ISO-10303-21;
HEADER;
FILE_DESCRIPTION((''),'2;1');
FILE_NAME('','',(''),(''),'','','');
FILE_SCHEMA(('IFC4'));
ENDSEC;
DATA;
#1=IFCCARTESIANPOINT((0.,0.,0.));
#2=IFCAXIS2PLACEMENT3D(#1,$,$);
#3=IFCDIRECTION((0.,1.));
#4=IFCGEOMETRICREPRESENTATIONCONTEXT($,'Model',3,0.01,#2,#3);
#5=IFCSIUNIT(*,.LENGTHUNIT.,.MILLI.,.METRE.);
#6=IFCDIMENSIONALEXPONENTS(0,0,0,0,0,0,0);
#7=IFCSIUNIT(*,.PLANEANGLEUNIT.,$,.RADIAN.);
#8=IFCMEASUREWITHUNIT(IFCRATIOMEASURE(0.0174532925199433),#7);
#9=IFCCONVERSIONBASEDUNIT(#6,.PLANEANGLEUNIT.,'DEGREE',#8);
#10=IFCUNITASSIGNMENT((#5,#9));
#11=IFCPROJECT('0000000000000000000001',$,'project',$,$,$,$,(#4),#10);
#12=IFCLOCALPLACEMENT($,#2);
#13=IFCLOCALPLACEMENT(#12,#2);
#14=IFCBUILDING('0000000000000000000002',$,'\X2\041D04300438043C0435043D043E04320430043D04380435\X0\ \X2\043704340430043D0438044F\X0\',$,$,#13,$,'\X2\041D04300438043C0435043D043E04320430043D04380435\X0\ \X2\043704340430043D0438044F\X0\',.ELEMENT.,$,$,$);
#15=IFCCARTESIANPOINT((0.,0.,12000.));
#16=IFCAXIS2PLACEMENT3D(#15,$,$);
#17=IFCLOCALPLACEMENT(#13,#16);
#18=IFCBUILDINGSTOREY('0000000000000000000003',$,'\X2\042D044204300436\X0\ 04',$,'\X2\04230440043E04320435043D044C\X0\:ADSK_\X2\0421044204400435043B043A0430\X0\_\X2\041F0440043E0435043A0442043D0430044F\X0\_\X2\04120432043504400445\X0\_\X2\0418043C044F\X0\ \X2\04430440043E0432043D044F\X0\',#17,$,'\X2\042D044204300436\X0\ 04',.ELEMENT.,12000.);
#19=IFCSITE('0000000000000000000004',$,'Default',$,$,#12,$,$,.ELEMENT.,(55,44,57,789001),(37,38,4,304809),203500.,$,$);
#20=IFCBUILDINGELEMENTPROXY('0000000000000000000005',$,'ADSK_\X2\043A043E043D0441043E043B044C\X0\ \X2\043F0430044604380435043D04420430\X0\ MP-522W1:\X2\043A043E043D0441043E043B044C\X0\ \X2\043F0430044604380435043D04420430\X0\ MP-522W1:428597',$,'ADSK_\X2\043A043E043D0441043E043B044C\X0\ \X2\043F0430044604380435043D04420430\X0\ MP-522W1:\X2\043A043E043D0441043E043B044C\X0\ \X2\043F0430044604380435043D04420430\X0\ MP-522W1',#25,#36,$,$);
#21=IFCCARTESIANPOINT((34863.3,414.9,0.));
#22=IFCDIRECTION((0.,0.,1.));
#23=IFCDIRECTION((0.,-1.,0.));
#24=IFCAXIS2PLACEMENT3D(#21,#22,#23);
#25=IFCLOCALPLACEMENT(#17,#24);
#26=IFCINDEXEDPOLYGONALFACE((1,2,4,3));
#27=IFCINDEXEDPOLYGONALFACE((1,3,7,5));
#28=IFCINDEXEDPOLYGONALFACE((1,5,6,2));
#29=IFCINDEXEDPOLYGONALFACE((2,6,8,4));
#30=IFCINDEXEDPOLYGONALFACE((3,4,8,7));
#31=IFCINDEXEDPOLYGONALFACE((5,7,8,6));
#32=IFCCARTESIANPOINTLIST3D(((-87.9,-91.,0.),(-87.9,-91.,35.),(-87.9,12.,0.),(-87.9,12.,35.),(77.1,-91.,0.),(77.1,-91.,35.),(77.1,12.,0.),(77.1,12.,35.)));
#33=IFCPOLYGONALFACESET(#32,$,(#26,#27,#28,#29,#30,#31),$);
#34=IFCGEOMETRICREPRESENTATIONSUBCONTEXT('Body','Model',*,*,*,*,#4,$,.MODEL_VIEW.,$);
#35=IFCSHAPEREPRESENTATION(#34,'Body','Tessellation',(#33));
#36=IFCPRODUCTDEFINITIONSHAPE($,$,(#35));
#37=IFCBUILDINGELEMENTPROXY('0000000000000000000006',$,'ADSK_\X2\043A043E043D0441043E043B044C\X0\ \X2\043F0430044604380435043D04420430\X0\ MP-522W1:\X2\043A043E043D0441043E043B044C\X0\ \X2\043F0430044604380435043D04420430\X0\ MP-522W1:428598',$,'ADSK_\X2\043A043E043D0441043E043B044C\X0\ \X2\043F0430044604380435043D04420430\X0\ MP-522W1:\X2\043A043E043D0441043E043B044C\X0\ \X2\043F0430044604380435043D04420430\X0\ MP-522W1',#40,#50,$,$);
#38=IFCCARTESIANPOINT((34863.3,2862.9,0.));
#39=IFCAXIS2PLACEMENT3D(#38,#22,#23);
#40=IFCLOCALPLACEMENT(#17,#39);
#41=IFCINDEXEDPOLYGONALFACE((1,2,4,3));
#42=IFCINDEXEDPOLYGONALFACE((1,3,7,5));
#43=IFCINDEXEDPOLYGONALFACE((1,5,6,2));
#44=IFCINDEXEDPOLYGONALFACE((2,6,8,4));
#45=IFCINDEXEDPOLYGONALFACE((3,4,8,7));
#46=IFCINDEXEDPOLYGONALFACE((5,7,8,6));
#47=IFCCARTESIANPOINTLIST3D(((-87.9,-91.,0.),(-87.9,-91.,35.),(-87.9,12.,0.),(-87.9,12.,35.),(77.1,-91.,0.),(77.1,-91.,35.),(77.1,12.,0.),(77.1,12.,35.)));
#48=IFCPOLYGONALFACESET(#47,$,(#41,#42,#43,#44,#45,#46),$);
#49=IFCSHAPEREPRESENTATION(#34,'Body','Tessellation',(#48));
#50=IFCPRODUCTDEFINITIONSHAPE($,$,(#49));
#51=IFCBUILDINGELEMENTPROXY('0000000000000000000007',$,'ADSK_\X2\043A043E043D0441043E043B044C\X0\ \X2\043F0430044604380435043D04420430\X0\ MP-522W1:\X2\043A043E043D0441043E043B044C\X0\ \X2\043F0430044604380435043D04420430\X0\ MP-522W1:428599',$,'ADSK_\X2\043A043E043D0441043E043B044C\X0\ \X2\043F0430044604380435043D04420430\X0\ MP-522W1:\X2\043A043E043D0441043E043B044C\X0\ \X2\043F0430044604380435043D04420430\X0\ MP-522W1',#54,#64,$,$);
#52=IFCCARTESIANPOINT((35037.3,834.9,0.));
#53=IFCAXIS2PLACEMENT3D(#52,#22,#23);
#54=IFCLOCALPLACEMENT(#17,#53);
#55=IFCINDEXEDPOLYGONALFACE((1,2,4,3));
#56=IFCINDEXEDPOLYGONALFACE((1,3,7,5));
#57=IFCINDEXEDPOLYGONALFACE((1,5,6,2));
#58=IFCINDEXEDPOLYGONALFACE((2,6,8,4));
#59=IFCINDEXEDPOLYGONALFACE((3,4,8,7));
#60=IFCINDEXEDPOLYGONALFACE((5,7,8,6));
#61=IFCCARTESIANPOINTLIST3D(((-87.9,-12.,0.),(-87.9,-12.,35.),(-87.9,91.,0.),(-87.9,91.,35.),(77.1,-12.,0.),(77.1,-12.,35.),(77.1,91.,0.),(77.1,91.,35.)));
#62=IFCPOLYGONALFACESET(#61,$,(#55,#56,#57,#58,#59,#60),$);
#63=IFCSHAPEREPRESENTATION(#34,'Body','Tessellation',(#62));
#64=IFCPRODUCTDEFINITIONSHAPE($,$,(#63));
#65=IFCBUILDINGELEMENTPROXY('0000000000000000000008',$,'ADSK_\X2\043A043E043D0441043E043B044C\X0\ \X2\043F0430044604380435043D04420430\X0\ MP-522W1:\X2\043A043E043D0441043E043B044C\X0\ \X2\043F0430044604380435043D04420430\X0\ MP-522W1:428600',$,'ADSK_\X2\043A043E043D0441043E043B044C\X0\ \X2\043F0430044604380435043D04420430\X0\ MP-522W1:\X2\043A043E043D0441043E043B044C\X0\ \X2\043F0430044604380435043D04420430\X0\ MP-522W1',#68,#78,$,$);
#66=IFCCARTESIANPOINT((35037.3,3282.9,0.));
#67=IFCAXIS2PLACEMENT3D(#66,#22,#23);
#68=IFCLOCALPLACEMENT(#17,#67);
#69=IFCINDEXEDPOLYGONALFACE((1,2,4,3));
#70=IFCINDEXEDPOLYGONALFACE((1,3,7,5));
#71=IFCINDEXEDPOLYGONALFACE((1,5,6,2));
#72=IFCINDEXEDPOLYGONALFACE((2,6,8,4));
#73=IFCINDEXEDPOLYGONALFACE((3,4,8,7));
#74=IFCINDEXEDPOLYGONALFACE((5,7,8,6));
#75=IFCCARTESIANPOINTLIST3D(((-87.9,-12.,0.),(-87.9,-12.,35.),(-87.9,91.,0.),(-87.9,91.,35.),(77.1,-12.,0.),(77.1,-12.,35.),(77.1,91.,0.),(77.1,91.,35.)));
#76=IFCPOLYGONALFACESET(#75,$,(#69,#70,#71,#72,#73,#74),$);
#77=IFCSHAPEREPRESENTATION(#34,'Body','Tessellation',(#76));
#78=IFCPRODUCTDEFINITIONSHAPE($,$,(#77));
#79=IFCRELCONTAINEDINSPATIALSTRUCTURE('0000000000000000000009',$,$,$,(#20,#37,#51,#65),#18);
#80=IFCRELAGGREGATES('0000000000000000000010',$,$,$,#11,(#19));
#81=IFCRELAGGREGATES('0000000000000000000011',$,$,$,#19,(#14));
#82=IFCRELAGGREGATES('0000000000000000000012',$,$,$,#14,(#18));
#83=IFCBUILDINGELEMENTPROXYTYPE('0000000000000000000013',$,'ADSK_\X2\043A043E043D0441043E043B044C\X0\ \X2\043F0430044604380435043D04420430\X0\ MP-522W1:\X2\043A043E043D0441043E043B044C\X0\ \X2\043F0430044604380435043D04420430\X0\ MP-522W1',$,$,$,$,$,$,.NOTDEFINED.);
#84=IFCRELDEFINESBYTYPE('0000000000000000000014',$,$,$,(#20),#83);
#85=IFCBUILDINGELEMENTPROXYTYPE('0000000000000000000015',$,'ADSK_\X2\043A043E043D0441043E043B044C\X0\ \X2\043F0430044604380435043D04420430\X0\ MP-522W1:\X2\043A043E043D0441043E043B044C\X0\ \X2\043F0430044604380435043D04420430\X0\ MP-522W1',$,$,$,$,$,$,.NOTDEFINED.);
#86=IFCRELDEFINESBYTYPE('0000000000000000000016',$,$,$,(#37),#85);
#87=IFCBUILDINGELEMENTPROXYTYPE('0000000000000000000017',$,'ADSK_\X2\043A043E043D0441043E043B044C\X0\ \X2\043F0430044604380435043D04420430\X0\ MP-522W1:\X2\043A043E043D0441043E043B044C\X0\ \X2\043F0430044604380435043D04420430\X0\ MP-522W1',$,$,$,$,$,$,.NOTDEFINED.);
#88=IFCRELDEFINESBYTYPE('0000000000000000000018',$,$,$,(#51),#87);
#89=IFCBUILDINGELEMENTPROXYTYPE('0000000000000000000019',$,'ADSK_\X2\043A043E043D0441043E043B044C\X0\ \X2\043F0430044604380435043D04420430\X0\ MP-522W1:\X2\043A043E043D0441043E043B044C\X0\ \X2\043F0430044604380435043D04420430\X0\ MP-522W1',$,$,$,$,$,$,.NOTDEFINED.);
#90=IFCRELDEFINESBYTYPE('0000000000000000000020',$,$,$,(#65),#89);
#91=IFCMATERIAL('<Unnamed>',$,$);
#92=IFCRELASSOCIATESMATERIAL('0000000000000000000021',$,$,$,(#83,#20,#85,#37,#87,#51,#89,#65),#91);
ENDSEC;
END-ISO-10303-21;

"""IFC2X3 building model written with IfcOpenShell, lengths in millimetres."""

from ifc_helpers import new_model, entity, si_unit, converted_unit, direction, frame, origin, origin_2d_with_axis, place, context, subcontext, project, spatial, rectangle, extrude, source, transform, mapped, material, type_object, type_shapes, element, save


model = new_model("IFC2X3")

# Units and contexts
model_context = context("Model", 3, precision=0.01, world=origin(), true_north=direction((0.0, 1.0)))
body_context = subcontext(model_context, "Body", "Model", "MODEL_VIEW")
ifc_project = project(units=[si_unit("LENGTHUNIT", "METRE", prefix="MILLI"), converted_unit("PLANEANGLEUNIT", "DEGREE", entity("IfcRatioMeasure", 0.0174532925199433), si_unit("PLANEANGLEUNIT", "RADIAN"), dimensions=[0, 0, 0, 0, 0, 0, 0])], contexts=[model_context])

# Site, building, storey
site_placement = place(None, origin())
site = spatial("IfcSite", under=ifc_project, at=site_placement, Name="Default", CompositionType="ELEMENT", RefLatitude=(55, 44, 57, 789001), RefLongitude=(37, 38, 4, 304809), RefElevation=203500.0)
building_placement = place(site_placement, origin())
building = spatial("IfcBuilding", under=site, at=building_placement, Name="Наименование здания", LongName="Наименование здания", CompositionType="ELEMENT")
storey_placement = place(building_placement, frame((0.0, 0.0, 12000.0)))
storey = spatial("IfcBuildingStorey", under=building, at=storey_placement, Name="Этаж 04", ObjectType="Уровень:ADSK_Стрелка_Проектная_Вверх_Имя уровня", LongName="Этаж 04", CompositionType="ELEMENT", Elevation=12000.0)

# Building element proxies
ifc_material = material(Name="<Unnamed>")
building_element_proxy_type_1 = type_object("IfcBuildingElementProxyType", Name="ADSK_консоль пациента MP-522W1:консоль пациента MP-522W1", PredefinedType="NOTDEFINED", material=ifc_material)
shared_shape_1 = source(origin(), body_context, "Body", "SweptSolid", [
    extrude(rectangle(XDim=165.0, YDim=103.0, at=origin_2d_with_axis()), frame((-5.4, -39.5, 0.0), z_axis=(0.0, 0.0, 1.0), x_axis=(-1.0, 0.0, 0.0)), (0.0, 0.0, 1.0), 35.0),
])
type_shapes(building_element_proxy_type_1, [shared_shape_1])
proxy_1_placement = place(storey_placement, frame((34863.3, 414.9, 0.0), z_axis=(0.0, 0.0, 1.0), x_axis=(0.0, -1.0, 0.0)))
element("IfcBuildingElementProxy", 1, at=proxy_1_placement, inside=storey, type_object=building_element_proxy_type_1, material=ifc_material, Name="ADSK_консоль пациента MP-522W1:консоль пациента MP-522W1:428597", ObjectType="ADSK_консоль пациента MP-522W1:консоль пациента MP-522W1", context=body_context, shape_type="MappedRepresentation", body=[
    mapped(shared_shape_1, transform((0.0, 0.0, 0.0), scale=1.0)),
])
building_element_proxy_type_2 = type_object("IfcBuildingElementProxyType", Name="ADSK_консоль пациента MP-522W1:консоль пациента MP-522W1", PredefinedType="NOTDEFINED", material=ifc_material)
type_shapes(building_element_proxy_type_2, [shared_shape_1])
proxy_2_placement = place(storey_placement, frame((34863.3, 2862.9, 0.0), z_axis=(0.0, 0.0, 1.0), x_axis=(0.0, -1.0, 0.0)))
element("IfcBuildingElementProxy", 2, at=proxy_2_placement, inside=storey, type_object=building_element_proxy_type_2, material=ifc_material, Name="ADSK_консоль пациента MP-522W1:консоль пациента MP-522W1:428598", ObjectType="ADSK_консоль пациента MP-522W1:консоль пациента MP-522W1", context=body_context, shape_type="MappedRepresentation", body=[
    mapped(shared_shape_1, transform((0.0, 0.0, 0.0), scale=1.0)),
])
building_element_proxy_type_3 = type_object("IfcBuildingElementProxyType", Name="ADSK_консоль пациента MP-522W1:консоль пациента MP-522W1", PredefinedType="NOTDEFINED", material=ifc_material)
shared_shape_2 = source(origin(), body_context, "Body", "SweptSolid", [
    extrude(rectangle(XDim=103.0, YDim=165.0, at=origin_2d_with_axis()), frame((-5.4, 39.5, 0.0), z_axis=(0.0, 0.0, 1.0), x_axis=(0.0, 1.0, 0.0)), (0.0, 0.0, 1.0), 35.0),
])
type_shapes(building_element_proxy_type_3, [shared_shape_2])
proxy_3_placement = place(storey_placement, frame((35037.3, 834.9, 0.0), z_axis=(0.0, 0.0, 1.0), x_axis=(0.0, -1.0, 0.0)))
element("IfcBuildingElementProxy", 3, at=proxy_3_placement, inside=storey, type_object=building_element_proxy_type_3, material=ifc_material, Name="ADSK_консоль пациента MP-522W1:консоль пациента MP-522W1:428599", ObjectType="ADSK_консоль пациента MP-522W1:консоль пациента MP-522W1", context=body_context, shape_type="MappedRepresentation", body=[
    mapped(shared_shape_2, transform((0.0, 0.0, 0.0), scale=1.0)),
])
building_element_proxy_type_4 = type_object("IfcBuildingElementProxyType", Name="ADSK_консоль пациента MP-522W1:консоль пациента MP-522W1", PredefinedType="NOTDEFINED", material=ifc_material)
type_shapes(building_element_proxy_type_4, [shared_shape_2])
proxy_4_placement = place(storey_placement, frame((35037.3, 3282.9, 0.0), z_axis=(0.0, 0.0, 1.0), x_axis=(0.0, -1.0, 0.0)))
element("IfcBuildingElementProxy", 4, at=proxy_4_placement, inside=storey, type_object=building_element_proxy_type_4, material=ifc_material, Name="ADSK_консоль пациента MP-522W1:консоль пациента MP-522W1:428600", ObjectType="ADSK_консоль пациента MP-522W1:консоль пациента MP-522W1", context=body_context, shape_type="MappedRepresentation", body=[
    mapped(shared_shape_2, transform((0.0, 0.0, 0.0), scale=1.0)),
])

save(model, "model.ifc")
